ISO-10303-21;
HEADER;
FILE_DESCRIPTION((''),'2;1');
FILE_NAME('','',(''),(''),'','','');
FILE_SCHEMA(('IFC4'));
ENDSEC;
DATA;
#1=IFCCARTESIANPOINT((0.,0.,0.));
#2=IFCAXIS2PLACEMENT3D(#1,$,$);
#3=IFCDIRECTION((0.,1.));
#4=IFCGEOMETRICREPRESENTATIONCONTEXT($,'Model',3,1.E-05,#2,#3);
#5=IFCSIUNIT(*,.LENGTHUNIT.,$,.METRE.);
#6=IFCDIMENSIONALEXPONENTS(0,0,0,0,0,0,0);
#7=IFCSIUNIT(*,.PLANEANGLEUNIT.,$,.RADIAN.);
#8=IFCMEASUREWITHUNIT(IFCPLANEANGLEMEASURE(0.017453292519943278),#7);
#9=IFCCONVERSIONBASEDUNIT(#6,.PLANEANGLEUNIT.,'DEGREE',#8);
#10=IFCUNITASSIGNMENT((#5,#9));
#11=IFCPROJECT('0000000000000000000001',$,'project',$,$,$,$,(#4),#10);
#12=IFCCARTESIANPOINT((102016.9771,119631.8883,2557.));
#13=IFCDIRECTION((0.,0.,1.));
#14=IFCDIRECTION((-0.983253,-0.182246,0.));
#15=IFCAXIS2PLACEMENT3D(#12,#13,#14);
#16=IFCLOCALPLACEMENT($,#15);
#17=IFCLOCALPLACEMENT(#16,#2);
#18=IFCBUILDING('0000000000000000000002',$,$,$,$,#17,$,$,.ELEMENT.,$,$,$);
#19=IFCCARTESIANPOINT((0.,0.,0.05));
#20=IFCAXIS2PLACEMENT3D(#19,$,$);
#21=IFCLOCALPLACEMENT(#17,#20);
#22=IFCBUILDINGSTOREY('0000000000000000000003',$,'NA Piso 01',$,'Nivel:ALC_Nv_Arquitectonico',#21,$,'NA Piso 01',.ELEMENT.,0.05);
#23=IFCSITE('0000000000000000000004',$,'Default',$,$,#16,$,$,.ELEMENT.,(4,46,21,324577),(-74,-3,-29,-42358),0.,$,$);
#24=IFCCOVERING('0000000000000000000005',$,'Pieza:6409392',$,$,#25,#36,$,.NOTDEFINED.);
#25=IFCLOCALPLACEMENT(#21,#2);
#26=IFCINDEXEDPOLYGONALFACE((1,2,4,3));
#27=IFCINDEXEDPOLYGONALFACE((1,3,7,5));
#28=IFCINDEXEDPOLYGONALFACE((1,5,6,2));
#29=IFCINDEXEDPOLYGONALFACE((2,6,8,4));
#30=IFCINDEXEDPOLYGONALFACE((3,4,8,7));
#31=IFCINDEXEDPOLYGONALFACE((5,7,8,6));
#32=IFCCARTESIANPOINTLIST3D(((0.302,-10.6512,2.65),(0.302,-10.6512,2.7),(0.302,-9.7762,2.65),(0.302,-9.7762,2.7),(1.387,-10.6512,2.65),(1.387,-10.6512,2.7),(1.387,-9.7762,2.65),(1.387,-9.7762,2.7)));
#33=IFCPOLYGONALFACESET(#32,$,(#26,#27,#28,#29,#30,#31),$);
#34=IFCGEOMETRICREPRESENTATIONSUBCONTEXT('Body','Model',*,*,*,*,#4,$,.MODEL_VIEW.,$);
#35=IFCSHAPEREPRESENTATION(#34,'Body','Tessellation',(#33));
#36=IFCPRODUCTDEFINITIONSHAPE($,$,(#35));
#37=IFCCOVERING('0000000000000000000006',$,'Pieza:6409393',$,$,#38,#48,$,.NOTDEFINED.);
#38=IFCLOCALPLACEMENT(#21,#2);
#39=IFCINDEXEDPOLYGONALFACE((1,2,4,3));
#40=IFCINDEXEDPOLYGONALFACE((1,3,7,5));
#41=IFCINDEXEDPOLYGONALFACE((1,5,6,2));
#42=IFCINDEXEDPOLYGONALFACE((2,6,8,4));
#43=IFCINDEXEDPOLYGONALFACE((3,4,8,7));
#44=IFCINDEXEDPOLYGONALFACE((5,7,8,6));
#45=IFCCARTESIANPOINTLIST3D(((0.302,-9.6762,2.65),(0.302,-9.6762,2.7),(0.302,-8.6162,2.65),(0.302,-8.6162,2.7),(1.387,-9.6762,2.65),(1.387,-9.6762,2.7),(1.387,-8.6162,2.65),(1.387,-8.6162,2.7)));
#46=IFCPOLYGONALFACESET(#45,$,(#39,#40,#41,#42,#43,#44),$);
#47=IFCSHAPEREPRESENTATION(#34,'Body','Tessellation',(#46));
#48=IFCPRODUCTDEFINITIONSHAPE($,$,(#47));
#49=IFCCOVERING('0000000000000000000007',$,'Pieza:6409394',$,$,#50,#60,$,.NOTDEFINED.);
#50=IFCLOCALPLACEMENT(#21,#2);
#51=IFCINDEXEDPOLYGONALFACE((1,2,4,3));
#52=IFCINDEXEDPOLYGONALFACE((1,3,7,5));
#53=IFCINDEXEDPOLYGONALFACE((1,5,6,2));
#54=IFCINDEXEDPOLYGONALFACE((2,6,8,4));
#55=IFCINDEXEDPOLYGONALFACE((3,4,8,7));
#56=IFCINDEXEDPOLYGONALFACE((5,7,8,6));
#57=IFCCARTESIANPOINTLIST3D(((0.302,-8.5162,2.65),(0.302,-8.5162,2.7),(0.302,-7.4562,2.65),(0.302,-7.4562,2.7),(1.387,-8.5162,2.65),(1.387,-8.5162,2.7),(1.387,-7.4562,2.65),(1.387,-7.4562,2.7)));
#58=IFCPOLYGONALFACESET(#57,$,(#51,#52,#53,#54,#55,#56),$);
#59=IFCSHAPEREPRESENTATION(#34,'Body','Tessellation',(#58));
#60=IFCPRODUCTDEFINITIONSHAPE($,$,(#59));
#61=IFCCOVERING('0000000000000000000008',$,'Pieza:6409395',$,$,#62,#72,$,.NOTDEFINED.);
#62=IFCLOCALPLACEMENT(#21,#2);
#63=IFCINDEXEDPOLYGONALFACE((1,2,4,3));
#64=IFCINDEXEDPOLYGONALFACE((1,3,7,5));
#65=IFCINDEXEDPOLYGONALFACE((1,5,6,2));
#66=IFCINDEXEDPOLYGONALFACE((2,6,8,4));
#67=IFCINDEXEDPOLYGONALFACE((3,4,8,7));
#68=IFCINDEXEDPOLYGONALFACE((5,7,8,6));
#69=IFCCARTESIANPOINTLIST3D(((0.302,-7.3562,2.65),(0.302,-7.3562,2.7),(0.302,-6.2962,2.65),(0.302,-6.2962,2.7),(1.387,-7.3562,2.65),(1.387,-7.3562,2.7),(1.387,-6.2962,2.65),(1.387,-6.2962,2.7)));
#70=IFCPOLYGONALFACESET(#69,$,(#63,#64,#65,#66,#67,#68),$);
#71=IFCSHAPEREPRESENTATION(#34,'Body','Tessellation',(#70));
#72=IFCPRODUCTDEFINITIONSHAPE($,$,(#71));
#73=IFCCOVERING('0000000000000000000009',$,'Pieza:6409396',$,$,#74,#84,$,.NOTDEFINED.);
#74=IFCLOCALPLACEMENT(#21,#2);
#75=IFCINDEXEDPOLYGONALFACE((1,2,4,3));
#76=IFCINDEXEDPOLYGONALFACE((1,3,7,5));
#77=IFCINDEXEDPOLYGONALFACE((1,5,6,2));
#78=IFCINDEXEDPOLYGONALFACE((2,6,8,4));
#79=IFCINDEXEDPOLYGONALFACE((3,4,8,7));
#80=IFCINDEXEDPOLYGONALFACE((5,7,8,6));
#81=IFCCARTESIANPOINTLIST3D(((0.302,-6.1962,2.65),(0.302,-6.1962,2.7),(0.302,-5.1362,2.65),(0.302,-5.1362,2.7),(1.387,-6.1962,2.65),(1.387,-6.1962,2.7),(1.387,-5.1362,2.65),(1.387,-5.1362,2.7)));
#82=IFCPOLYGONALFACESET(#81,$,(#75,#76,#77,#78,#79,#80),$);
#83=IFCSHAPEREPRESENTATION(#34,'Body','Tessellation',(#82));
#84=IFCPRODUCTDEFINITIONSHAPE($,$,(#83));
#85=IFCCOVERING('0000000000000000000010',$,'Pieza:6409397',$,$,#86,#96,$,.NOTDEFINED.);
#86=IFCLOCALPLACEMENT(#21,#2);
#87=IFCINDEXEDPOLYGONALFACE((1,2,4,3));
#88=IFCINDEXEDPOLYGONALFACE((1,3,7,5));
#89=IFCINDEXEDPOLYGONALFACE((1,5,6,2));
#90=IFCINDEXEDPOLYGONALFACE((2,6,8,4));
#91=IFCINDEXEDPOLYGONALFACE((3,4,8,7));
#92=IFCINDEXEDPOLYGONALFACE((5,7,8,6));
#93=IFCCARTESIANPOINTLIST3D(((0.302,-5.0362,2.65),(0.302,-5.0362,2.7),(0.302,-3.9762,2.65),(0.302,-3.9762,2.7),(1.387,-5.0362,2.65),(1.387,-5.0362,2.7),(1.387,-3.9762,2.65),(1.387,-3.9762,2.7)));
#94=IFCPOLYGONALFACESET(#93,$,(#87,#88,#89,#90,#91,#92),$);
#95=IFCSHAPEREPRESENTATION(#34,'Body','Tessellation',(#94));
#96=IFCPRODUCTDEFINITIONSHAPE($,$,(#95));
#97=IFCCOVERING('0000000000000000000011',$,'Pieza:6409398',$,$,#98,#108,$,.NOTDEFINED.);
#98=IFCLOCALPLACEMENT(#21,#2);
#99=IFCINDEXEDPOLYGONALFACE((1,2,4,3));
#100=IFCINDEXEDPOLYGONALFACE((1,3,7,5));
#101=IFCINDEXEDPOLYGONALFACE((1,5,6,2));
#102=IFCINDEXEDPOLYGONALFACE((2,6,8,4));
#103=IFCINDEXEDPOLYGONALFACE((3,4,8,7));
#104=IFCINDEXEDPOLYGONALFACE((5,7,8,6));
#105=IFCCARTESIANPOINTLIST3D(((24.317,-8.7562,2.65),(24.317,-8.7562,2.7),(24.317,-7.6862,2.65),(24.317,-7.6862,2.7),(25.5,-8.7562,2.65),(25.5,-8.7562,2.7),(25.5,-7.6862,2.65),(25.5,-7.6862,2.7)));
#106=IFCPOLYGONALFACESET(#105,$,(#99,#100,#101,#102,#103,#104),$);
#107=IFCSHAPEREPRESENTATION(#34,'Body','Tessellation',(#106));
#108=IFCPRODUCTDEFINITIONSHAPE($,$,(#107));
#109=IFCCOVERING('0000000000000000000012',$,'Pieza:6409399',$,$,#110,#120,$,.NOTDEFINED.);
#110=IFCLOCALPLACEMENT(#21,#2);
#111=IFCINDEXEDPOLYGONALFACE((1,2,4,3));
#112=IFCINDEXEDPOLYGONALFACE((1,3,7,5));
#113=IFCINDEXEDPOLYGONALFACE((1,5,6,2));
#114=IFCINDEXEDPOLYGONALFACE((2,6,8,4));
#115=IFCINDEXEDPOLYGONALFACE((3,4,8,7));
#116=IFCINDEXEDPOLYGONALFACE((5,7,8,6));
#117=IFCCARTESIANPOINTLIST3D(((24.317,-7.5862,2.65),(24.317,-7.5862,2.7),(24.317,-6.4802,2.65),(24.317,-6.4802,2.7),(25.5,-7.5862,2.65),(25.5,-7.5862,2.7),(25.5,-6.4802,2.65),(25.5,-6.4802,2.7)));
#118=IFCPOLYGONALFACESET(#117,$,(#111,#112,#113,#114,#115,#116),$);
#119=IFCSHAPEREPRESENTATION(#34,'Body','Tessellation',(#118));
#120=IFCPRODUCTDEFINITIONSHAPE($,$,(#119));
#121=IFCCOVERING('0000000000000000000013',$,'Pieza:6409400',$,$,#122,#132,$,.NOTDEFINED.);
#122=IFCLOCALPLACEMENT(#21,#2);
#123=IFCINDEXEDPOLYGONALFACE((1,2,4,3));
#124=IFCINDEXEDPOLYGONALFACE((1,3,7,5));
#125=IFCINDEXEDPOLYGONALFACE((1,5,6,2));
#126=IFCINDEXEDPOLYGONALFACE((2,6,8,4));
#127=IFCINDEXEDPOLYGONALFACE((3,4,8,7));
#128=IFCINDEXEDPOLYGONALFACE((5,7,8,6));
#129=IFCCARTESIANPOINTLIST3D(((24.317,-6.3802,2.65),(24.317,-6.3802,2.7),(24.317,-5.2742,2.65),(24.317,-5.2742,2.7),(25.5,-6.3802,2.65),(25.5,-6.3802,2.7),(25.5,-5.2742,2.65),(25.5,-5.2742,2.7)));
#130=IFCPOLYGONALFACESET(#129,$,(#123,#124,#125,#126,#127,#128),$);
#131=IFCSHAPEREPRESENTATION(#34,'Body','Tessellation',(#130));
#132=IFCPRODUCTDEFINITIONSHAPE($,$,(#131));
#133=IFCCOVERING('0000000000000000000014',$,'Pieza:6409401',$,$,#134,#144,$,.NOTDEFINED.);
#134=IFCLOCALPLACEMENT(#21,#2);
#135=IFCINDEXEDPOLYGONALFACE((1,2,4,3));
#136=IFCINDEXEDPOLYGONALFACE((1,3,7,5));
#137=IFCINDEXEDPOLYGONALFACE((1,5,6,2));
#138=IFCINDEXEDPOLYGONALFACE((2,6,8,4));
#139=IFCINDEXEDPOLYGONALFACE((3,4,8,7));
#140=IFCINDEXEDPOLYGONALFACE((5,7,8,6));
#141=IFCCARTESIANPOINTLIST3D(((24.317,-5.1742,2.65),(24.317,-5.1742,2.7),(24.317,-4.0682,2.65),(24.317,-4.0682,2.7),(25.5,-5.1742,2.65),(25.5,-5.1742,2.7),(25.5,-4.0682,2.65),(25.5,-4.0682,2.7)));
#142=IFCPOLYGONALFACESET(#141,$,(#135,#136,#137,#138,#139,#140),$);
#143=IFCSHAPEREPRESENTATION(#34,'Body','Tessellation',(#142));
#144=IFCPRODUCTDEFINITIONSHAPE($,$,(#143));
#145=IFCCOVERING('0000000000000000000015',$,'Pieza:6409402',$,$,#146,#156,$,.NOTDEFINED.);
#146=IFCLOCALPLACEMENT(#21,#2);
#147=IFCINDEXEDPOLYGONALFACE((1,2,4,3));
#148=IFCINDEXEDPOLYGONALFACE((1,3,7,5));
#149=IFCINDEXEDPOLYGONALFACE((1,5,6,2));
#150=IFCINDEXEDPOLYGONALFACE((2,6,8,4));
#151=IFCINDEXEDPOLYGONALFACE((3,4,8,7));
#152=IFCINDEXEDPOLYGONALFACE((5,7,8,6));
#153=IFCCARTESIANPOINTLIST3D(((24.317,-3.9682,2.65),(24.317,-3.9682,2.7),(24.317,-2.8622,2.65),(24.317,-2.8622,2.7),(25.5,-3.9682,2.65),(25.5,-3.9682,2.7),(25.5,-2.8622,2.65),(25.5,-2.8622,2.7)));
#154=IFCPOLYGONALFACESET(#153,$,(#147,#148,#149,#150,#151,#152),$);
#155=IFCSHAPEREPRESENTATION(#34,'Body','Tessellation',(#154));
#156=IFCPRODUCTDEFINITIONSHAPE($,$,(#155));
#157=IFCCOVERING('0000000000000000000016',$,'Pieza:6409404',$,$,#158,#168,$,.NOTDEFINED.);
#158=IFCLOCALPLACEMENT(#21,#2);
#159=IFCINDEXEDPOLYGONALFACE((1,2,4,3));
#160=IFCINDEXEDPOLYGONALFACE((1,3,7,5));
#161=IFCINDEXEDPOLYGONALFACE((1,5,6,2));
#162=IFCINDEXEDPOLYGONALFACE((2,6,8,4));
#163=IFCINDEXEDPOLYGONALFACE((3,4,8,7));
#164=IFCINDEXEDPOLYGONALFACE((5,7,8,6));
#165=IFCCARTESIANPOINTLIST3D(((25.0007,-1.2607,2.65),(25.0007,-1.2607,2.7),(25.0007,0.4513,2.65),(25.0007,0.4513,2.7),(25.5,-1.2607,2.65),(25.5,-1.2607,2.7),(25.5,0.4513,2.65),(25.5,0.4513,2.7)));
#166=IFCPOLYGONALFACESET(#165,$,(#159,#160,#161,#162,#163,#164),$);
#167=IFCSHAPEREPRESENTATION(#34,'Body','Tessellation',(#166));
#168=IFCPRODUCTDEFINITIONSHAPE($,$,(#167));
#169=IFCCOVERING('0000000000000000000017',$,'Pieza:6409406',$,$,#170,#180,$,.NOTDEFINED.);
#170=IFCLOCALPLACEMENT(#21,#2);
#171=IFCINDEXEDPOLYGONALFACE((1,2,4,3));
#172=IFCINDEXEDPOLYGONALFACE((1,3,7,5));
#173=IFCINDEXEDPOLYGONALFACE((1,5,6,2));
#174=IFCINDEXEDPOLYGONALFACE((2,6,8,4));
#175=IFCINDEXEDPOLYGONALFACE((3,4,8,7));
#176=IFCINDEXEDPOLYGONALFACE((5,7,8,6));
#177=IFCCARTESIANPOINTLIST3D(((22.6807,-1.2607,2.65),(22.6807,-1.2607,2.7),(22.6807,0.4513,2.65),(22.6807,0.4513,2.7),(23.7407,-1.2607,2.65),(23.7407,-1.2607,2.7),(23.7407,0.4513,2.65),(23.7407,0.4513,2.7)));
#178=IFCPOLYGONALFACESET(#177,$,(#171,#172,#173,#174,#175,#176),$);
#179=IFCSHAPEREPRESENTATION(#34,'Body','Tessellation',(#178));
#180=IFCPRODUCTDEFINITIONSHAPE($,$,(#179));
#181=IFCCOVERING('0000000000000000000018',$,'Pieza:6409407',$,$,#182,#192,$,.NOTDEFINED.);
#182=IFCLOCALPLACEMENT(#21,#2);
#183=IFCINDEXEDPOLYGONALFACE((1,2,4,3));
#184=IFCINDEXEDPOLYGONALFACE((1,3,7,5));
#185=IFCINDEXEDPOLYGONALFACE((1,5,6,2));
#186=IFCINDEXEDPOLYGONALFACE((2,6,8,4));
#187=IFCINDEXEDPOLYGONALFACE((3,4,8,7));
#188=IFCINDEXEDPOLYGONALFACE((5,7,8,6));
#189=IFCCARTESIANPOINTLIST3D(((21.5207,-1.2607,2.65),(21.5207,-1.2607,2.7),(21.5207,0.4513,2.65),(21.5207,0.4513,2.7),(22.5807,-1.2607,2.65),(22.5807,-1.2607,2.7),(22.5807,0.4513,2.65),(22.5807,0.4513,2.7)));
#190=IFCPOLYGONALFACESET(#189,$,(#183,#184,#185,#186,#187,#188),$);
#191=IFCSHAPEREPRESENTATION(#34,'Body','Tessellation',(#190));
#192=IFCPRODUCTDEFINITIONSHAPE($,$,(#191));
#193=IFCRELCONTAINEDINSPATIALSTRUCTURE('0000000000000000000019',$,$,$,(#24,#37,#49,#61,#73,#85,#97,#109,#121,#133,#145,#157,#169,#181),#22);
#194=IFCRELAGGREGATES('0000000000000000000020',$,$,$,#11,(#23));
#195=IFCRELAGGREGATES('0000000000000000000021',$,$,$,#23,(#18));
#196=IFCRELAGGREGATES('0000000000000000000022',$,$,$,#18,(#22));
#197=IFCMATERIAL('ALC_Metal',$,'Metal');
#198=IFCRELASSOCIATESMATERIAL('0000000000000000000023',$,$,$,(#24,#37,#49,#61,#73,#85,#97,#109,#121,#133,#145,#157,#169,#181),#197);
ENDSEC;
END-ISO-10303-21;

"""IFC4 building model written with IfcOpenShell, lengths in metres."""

from ifc_helpers import new_model, entity, si_unit, converted_unit, direction, frame, frame_2d, origin, origin_2d_with_axis, place, context, subcontext, project, spatial, rectangle, extrude, material, element, save


model = new_model("IFC4")

# Units and contexts
model_context = context("Model", 3, precision=1e-05, world=origin(), true_north=direction((0.0, 1.0)))
body_context = subcontext(model_context, "Body", "Model", "MODEL_VIEW")
ifc_project = project(units=[si_unit("LENGTHUNIT", "METRE"), converted_unit("PLANEANGLEUNIT", "DEGREE", entity("IfcPlaneAngleMeasure", 0.017453292519943278), si_unit("PLANEANGLEUNIT", "RADIAN"), dimensions=[0, 0, 0, 0, 0, 0, 0])], contexts=[model_context])

# Site, building, storey
site_placement = place(None, frame((102016.9771, 119631.8883, 2557.0), z_axis=(0.0, 0.0, 1.0), x_axis=(-0.983253, -0.182246, 0.0)))
site = spatial("IfcSite", under=ifc_project, at=site_placement, Name="Default", CompositionType="ELEMENT", RefLatitude=(4, 46, 21, 324577), RefLongitude=(-74, -3, -29, -42358), RefElevation=0.0)
building_placement = place(site_placement, origin())
building = spatial("IfcBuilding", under=site, at=building_placement, CompositionType="ELEMENT")
storey_placement = place(building_placement, frame((0.0, 0.0, 0.05)))
storey = spatial("IfcBuildingStorey", under=building, at=storey_placement, Name="NA Piso 01", ObjectType="Nivel:ALC_Nv_Arquitectonico", LongName="NA Piso 01", CompositionType="ELEMENT", Elevation=0.05)

# Coverings
ifc_material_1 = material(Name="ALC_Metal", Category="Metal")
covering_1_placement = place(storey_placement, frame((0.0, 0.0, 2.65)))
element("IfcCovering", 1, at=covering_1_placement, inside=storey, material=ifc_material_1, Name="Pieza:6409392", PredefinedType="NOTDEFINED", context=body_context, shape_type="SweptSolid", body=[
    extrude(rectangle(XDim=0.875, YDim=1.085, at=frame_2d((0.0, 0.0), x_axis=(1.0, 0.0))), frame((0.8445, -10.2137, 0.0), z_axis=(0.0, 0.0, 1.0), x_axis=(0.0, -1.0, 0.0)), (0.0, 0.0, 1.0), 0.05),
])
covering_2_placement = place(storey_placement, frame((0.0, 0.0, 2.65)))
element("IfcCovering", 2, at=covering_2_placement, inside=storey, material=ifc_material_1, Name="Pieza:6409393", PredefinedType="NOTDEFINED", context=body_context, shape_type="SweptSolid", body=[
    extrude(rectangle(XDim=1.06, YDim=1.085, at=frame_2d((0.0, 0.0), x_axis=(1.0, 0.0))), frame((0.8445, -9.1462, 0.0), z_axis=(0.0, 0.0, 1.0), x_axis=(0.0, -1.0, 0.0)), (0.0, 0.0, 1.0), 0.05),
])
covering_3_placement = place(storey_placement, frame((0.0, 0.0, 2.65)))
element("IfcCovering", 3, at=covering_3_placement, inside=storey, material=ifc_material_1, Name="Pieza:6409394", PredefinedType="NOTDEFINED", context=body_context, shape_type="SweptSolid", body=[
    extrude(rectangle(XDim=1.06, YDim=1.085, at=frame_2d((0.0, 0.0), x_axis=(1.0, 0.0))), frame((0.8445, -7.9862, 0.0), z_axis=(0.0, 0.0, 1.0), x_axis=(0.0, -1.0, 0.0)), (0.0, 0.0, 1.0), 0.05),
])
covering_4_placement = place(storey_placement, frame((0.0, 0.0, 2.65)))
element("IfcCovering", 4, at=covering_4_placement, inside=storey, material=ifc_material_1, Name="Pieza:6409395", PredefinedType="NOTDEFINED", context=body_context, shape_type="SweptSolid", body=[
    extrude(rectangle(XDim=1.06, YDim=1.085, at=frame_2d((0.0, 0.0), x_axis=(1.0, 0.0))), frame((0.8445, -6.8262, 0.0), z_axis=(0.0, 0.0, 1.0), x_axis=(0.0, -1.0, 0.0)), (0.0, 0.0, 1.0), 0.05),
])
covering_5_placement = place(storey_placement, frame((0.0, 0.0, 2.65)))
element("IfcCovering", 5, at=covering_5_placement, inside=storey, material=ifc_material_1, Name="Pieza:6409396", PredefinedType="NOTDEFINED", context=body_context, shape_type="SweptSolid", body=[
    extrude(rectangle(XDim=1.06, YDim=1.085, at=frame_2d((0.0, 0.0), x_axis=(1.0, 0.0))), frame((0.8445, -5.6662, 0.0), z_axis=(0.0, 0.0, 1.0), x_axis=(0.0, -1.0, 0.0)), (0.0, 0.0, 1.0), 0.05),
])
covering_6_placement = place(storey_placement, frame((0.0, 0.0, 2.65)))
element("IfcCovering", 6, at=covering_6_placement, inside=storey, material=ifc_material_1, Name="Pieza:6409397", PredefinedType="NOTDEFINED", context=body_context, shape_type="SweptSolid", body=[
    extrude(rectangle(XDim=1.06, YDim=1.085, at=frame_2d((0.0, 0.0), x_axis=(1.0, 0.0))), frame((0.8445, -4.5062, 0.0), z_axis=(0.0, 0.0, 1.0), x_axis=(0.0, -1.0, 0.0)), (0.0, 0.0, 1.0), 0.05),
])
covering_7_placement = place(storey_placement, frame((0.0, 0.0, 2.65)))
element("IfcCovering", 7, at=covering_7_placement, inside=storey, material=ifc_material_1, Name="Pieza:6409398", PredefinedType="NOTDEFINED", context=body_context, shape_type="SweptSolid", body=[
    extrude(rectangle(XDim=1.07, YDim=1.183, at=origin_2d_with_axis()), frame((24.9085, -8.2212, 0.0), z_axis=(0.0, 0.0, 1.0), x_axis=(0.0, -1.0, 0.0)), (0.0, 0.0, 1.0), 0.05),
])
covering_8_placement = place(storey_placement, frame((0.0, 0.0, 2.65)))
element("IfcCovering", 8, at=covering_8_placement, inside=storey, material=ifc_material_1, Name="Pieza:6409399", PredefinedType="NOTDEFINED", context=body_context, shape_type="SweptSolid", body=[
    extrude(rectangle(XDim=1.106, YDim=1.183, at=frame_2d((0.0, 0.0), x_axis=(1.0, 0.0))), frame((24.9085, -7.0332, 0.0), z_axis=(0.0, 0.0, 1.0), x_axis=(0.0, -1.0, 0.0)), (0.0, 0.0, 1.0), 0.05),
])
covering_9_placement = place(storey_placement, frame((0.0, 0.0, 2.65)))
element("IfcCovering", 9, at=covering_9_placement, inside=storey, material=ifc_material_1, Name="Pieza:6409400", PredefinedType="NOTDEFINED", context=body_context, shape_type="SweptSolid", body=[
    extrude(rectangle(XDim=1.106, YDim=1.183, at=frame_2d((0.0, 0.0), x_axis=(1.0, 0.0))), frame((24.9085, -5.8272, 0.0), z_axis=(0.0, 0.0, 1.0), x_axis=(0.0, -1.0, 0.0)), (0.0, 0.0, 1.0), 0.05),
])
covering_10_placement = place(storey_placement, frame((0.0, 0.0, 2.65)))
element("IfcCovering", 10, at=covering_10_placement, inside=storey, material=ifc_material_1, Name="Pieza:6409401", PredefinedType="NOTDEFINED", context=body_context, shape_type="SweptSolid", body=[
    extrude(rectangle(XDim=1.106, YDim=1.183, at=frame_2d((0.0, 0.0), x_axis=(1.0, 0.0))), frame((24.9085, -4.6212, 0.0), z_axis=(0.0, 0.0, 1.0), x_axis=(0.0, -1.0, 0.0)), (0.0, 0.0, 1.0), 0.05),
])
covering_11_placement = place(storey_placement, frame((0.0, 0.0, 2.65)))
element("IfcCovering", 11, at=covering_11_placement, inside=storey, material=ifc_material_1, Name="Pieza:6409402", PredefinedType="NOTDEFINED", context=body_context, shape_type="SweptSolid", body=[
    extrude(rectangle(XDim=1.106, YDim=1.183, at=frame_2d((0.0, 0.0), x_axis=(1.0, 0.0))), frame((24.9085, -3.4152, 0.0), z_axis=(0.0, 0.0, 1.0), x_axis=(0.0, -1.0, 0.0)), (0.0, 0.0, 1.0), 0.05),
])
covering_12_placement = place(storey_placement, frame((0.0, 0.0, 2.65)))
element("IfcCovering", 12, at=covering_12_placement, inside=storey, material=ifc_material_1, Name="Pieza:6409404", PredefinedType="NOTDEFINED", context=body_context, shape_type="SweptSolid", body=[
    extrude(rectangle(XDim=1.712, YDim=0.4993, at=frame_2d((0.0, 0.0), x_axis=(1.0, 0.0))), frame((25.2504, -0.4047, 0.0), z_axis=(0.0, 0.0, 1.0), x_axis=(0.0, -1.0, 0.0)), (0.0, 0.0, 1.0), 0.05),
])
covering_13_placement = place(storey_placement, frame((0.0, 0.0, 2.65)))
element("IfcCovering", 13, at=covering_13_placement, inside=storey, material=ifc_material_1, Name="Pieza:6409406", PredefinedType="NOTDEFINED", context=body_context, shape_type="SweptSolid", body=[
    extrude(rectangle(XDim=1.712, YDim=1.06, at=frame_2d((0.0, 0.0), x_axis=(1.0, 0.0))), frame((23.2107, -0.4047, 0.0), z_axis=(0.0, 0.0, 1.0), x_axis=(0.0, -1.0, 0.0)), (0.0, 0.0, 1.0), 0.05),
])
covering_14_placement = place(storey_placement, frame((0.0, 0.0, 2.65)))
element("IfcCovering", 14, at=covering_14_placement, inside=storey, material=ifc_material_1, Name="Pieza:6409407", PredefinedType="NOTDEFINED", context=body_context, shape_type="SweptSolid", body=[
    extrude(rectangle(XDim=1.712, YDim=1.06, at=frame_2d((0.0, 0.0), x_axis=(1.0, 0.0))), frame((22.0507, -0.4047, 0.0), z_axis=(0.0, 0.0, 1.0), x_axis=(0.0, -1.0, 0.0)), (0.0, 0.0, 1.0), 0.05),
])

save(model, "model.ifc")
